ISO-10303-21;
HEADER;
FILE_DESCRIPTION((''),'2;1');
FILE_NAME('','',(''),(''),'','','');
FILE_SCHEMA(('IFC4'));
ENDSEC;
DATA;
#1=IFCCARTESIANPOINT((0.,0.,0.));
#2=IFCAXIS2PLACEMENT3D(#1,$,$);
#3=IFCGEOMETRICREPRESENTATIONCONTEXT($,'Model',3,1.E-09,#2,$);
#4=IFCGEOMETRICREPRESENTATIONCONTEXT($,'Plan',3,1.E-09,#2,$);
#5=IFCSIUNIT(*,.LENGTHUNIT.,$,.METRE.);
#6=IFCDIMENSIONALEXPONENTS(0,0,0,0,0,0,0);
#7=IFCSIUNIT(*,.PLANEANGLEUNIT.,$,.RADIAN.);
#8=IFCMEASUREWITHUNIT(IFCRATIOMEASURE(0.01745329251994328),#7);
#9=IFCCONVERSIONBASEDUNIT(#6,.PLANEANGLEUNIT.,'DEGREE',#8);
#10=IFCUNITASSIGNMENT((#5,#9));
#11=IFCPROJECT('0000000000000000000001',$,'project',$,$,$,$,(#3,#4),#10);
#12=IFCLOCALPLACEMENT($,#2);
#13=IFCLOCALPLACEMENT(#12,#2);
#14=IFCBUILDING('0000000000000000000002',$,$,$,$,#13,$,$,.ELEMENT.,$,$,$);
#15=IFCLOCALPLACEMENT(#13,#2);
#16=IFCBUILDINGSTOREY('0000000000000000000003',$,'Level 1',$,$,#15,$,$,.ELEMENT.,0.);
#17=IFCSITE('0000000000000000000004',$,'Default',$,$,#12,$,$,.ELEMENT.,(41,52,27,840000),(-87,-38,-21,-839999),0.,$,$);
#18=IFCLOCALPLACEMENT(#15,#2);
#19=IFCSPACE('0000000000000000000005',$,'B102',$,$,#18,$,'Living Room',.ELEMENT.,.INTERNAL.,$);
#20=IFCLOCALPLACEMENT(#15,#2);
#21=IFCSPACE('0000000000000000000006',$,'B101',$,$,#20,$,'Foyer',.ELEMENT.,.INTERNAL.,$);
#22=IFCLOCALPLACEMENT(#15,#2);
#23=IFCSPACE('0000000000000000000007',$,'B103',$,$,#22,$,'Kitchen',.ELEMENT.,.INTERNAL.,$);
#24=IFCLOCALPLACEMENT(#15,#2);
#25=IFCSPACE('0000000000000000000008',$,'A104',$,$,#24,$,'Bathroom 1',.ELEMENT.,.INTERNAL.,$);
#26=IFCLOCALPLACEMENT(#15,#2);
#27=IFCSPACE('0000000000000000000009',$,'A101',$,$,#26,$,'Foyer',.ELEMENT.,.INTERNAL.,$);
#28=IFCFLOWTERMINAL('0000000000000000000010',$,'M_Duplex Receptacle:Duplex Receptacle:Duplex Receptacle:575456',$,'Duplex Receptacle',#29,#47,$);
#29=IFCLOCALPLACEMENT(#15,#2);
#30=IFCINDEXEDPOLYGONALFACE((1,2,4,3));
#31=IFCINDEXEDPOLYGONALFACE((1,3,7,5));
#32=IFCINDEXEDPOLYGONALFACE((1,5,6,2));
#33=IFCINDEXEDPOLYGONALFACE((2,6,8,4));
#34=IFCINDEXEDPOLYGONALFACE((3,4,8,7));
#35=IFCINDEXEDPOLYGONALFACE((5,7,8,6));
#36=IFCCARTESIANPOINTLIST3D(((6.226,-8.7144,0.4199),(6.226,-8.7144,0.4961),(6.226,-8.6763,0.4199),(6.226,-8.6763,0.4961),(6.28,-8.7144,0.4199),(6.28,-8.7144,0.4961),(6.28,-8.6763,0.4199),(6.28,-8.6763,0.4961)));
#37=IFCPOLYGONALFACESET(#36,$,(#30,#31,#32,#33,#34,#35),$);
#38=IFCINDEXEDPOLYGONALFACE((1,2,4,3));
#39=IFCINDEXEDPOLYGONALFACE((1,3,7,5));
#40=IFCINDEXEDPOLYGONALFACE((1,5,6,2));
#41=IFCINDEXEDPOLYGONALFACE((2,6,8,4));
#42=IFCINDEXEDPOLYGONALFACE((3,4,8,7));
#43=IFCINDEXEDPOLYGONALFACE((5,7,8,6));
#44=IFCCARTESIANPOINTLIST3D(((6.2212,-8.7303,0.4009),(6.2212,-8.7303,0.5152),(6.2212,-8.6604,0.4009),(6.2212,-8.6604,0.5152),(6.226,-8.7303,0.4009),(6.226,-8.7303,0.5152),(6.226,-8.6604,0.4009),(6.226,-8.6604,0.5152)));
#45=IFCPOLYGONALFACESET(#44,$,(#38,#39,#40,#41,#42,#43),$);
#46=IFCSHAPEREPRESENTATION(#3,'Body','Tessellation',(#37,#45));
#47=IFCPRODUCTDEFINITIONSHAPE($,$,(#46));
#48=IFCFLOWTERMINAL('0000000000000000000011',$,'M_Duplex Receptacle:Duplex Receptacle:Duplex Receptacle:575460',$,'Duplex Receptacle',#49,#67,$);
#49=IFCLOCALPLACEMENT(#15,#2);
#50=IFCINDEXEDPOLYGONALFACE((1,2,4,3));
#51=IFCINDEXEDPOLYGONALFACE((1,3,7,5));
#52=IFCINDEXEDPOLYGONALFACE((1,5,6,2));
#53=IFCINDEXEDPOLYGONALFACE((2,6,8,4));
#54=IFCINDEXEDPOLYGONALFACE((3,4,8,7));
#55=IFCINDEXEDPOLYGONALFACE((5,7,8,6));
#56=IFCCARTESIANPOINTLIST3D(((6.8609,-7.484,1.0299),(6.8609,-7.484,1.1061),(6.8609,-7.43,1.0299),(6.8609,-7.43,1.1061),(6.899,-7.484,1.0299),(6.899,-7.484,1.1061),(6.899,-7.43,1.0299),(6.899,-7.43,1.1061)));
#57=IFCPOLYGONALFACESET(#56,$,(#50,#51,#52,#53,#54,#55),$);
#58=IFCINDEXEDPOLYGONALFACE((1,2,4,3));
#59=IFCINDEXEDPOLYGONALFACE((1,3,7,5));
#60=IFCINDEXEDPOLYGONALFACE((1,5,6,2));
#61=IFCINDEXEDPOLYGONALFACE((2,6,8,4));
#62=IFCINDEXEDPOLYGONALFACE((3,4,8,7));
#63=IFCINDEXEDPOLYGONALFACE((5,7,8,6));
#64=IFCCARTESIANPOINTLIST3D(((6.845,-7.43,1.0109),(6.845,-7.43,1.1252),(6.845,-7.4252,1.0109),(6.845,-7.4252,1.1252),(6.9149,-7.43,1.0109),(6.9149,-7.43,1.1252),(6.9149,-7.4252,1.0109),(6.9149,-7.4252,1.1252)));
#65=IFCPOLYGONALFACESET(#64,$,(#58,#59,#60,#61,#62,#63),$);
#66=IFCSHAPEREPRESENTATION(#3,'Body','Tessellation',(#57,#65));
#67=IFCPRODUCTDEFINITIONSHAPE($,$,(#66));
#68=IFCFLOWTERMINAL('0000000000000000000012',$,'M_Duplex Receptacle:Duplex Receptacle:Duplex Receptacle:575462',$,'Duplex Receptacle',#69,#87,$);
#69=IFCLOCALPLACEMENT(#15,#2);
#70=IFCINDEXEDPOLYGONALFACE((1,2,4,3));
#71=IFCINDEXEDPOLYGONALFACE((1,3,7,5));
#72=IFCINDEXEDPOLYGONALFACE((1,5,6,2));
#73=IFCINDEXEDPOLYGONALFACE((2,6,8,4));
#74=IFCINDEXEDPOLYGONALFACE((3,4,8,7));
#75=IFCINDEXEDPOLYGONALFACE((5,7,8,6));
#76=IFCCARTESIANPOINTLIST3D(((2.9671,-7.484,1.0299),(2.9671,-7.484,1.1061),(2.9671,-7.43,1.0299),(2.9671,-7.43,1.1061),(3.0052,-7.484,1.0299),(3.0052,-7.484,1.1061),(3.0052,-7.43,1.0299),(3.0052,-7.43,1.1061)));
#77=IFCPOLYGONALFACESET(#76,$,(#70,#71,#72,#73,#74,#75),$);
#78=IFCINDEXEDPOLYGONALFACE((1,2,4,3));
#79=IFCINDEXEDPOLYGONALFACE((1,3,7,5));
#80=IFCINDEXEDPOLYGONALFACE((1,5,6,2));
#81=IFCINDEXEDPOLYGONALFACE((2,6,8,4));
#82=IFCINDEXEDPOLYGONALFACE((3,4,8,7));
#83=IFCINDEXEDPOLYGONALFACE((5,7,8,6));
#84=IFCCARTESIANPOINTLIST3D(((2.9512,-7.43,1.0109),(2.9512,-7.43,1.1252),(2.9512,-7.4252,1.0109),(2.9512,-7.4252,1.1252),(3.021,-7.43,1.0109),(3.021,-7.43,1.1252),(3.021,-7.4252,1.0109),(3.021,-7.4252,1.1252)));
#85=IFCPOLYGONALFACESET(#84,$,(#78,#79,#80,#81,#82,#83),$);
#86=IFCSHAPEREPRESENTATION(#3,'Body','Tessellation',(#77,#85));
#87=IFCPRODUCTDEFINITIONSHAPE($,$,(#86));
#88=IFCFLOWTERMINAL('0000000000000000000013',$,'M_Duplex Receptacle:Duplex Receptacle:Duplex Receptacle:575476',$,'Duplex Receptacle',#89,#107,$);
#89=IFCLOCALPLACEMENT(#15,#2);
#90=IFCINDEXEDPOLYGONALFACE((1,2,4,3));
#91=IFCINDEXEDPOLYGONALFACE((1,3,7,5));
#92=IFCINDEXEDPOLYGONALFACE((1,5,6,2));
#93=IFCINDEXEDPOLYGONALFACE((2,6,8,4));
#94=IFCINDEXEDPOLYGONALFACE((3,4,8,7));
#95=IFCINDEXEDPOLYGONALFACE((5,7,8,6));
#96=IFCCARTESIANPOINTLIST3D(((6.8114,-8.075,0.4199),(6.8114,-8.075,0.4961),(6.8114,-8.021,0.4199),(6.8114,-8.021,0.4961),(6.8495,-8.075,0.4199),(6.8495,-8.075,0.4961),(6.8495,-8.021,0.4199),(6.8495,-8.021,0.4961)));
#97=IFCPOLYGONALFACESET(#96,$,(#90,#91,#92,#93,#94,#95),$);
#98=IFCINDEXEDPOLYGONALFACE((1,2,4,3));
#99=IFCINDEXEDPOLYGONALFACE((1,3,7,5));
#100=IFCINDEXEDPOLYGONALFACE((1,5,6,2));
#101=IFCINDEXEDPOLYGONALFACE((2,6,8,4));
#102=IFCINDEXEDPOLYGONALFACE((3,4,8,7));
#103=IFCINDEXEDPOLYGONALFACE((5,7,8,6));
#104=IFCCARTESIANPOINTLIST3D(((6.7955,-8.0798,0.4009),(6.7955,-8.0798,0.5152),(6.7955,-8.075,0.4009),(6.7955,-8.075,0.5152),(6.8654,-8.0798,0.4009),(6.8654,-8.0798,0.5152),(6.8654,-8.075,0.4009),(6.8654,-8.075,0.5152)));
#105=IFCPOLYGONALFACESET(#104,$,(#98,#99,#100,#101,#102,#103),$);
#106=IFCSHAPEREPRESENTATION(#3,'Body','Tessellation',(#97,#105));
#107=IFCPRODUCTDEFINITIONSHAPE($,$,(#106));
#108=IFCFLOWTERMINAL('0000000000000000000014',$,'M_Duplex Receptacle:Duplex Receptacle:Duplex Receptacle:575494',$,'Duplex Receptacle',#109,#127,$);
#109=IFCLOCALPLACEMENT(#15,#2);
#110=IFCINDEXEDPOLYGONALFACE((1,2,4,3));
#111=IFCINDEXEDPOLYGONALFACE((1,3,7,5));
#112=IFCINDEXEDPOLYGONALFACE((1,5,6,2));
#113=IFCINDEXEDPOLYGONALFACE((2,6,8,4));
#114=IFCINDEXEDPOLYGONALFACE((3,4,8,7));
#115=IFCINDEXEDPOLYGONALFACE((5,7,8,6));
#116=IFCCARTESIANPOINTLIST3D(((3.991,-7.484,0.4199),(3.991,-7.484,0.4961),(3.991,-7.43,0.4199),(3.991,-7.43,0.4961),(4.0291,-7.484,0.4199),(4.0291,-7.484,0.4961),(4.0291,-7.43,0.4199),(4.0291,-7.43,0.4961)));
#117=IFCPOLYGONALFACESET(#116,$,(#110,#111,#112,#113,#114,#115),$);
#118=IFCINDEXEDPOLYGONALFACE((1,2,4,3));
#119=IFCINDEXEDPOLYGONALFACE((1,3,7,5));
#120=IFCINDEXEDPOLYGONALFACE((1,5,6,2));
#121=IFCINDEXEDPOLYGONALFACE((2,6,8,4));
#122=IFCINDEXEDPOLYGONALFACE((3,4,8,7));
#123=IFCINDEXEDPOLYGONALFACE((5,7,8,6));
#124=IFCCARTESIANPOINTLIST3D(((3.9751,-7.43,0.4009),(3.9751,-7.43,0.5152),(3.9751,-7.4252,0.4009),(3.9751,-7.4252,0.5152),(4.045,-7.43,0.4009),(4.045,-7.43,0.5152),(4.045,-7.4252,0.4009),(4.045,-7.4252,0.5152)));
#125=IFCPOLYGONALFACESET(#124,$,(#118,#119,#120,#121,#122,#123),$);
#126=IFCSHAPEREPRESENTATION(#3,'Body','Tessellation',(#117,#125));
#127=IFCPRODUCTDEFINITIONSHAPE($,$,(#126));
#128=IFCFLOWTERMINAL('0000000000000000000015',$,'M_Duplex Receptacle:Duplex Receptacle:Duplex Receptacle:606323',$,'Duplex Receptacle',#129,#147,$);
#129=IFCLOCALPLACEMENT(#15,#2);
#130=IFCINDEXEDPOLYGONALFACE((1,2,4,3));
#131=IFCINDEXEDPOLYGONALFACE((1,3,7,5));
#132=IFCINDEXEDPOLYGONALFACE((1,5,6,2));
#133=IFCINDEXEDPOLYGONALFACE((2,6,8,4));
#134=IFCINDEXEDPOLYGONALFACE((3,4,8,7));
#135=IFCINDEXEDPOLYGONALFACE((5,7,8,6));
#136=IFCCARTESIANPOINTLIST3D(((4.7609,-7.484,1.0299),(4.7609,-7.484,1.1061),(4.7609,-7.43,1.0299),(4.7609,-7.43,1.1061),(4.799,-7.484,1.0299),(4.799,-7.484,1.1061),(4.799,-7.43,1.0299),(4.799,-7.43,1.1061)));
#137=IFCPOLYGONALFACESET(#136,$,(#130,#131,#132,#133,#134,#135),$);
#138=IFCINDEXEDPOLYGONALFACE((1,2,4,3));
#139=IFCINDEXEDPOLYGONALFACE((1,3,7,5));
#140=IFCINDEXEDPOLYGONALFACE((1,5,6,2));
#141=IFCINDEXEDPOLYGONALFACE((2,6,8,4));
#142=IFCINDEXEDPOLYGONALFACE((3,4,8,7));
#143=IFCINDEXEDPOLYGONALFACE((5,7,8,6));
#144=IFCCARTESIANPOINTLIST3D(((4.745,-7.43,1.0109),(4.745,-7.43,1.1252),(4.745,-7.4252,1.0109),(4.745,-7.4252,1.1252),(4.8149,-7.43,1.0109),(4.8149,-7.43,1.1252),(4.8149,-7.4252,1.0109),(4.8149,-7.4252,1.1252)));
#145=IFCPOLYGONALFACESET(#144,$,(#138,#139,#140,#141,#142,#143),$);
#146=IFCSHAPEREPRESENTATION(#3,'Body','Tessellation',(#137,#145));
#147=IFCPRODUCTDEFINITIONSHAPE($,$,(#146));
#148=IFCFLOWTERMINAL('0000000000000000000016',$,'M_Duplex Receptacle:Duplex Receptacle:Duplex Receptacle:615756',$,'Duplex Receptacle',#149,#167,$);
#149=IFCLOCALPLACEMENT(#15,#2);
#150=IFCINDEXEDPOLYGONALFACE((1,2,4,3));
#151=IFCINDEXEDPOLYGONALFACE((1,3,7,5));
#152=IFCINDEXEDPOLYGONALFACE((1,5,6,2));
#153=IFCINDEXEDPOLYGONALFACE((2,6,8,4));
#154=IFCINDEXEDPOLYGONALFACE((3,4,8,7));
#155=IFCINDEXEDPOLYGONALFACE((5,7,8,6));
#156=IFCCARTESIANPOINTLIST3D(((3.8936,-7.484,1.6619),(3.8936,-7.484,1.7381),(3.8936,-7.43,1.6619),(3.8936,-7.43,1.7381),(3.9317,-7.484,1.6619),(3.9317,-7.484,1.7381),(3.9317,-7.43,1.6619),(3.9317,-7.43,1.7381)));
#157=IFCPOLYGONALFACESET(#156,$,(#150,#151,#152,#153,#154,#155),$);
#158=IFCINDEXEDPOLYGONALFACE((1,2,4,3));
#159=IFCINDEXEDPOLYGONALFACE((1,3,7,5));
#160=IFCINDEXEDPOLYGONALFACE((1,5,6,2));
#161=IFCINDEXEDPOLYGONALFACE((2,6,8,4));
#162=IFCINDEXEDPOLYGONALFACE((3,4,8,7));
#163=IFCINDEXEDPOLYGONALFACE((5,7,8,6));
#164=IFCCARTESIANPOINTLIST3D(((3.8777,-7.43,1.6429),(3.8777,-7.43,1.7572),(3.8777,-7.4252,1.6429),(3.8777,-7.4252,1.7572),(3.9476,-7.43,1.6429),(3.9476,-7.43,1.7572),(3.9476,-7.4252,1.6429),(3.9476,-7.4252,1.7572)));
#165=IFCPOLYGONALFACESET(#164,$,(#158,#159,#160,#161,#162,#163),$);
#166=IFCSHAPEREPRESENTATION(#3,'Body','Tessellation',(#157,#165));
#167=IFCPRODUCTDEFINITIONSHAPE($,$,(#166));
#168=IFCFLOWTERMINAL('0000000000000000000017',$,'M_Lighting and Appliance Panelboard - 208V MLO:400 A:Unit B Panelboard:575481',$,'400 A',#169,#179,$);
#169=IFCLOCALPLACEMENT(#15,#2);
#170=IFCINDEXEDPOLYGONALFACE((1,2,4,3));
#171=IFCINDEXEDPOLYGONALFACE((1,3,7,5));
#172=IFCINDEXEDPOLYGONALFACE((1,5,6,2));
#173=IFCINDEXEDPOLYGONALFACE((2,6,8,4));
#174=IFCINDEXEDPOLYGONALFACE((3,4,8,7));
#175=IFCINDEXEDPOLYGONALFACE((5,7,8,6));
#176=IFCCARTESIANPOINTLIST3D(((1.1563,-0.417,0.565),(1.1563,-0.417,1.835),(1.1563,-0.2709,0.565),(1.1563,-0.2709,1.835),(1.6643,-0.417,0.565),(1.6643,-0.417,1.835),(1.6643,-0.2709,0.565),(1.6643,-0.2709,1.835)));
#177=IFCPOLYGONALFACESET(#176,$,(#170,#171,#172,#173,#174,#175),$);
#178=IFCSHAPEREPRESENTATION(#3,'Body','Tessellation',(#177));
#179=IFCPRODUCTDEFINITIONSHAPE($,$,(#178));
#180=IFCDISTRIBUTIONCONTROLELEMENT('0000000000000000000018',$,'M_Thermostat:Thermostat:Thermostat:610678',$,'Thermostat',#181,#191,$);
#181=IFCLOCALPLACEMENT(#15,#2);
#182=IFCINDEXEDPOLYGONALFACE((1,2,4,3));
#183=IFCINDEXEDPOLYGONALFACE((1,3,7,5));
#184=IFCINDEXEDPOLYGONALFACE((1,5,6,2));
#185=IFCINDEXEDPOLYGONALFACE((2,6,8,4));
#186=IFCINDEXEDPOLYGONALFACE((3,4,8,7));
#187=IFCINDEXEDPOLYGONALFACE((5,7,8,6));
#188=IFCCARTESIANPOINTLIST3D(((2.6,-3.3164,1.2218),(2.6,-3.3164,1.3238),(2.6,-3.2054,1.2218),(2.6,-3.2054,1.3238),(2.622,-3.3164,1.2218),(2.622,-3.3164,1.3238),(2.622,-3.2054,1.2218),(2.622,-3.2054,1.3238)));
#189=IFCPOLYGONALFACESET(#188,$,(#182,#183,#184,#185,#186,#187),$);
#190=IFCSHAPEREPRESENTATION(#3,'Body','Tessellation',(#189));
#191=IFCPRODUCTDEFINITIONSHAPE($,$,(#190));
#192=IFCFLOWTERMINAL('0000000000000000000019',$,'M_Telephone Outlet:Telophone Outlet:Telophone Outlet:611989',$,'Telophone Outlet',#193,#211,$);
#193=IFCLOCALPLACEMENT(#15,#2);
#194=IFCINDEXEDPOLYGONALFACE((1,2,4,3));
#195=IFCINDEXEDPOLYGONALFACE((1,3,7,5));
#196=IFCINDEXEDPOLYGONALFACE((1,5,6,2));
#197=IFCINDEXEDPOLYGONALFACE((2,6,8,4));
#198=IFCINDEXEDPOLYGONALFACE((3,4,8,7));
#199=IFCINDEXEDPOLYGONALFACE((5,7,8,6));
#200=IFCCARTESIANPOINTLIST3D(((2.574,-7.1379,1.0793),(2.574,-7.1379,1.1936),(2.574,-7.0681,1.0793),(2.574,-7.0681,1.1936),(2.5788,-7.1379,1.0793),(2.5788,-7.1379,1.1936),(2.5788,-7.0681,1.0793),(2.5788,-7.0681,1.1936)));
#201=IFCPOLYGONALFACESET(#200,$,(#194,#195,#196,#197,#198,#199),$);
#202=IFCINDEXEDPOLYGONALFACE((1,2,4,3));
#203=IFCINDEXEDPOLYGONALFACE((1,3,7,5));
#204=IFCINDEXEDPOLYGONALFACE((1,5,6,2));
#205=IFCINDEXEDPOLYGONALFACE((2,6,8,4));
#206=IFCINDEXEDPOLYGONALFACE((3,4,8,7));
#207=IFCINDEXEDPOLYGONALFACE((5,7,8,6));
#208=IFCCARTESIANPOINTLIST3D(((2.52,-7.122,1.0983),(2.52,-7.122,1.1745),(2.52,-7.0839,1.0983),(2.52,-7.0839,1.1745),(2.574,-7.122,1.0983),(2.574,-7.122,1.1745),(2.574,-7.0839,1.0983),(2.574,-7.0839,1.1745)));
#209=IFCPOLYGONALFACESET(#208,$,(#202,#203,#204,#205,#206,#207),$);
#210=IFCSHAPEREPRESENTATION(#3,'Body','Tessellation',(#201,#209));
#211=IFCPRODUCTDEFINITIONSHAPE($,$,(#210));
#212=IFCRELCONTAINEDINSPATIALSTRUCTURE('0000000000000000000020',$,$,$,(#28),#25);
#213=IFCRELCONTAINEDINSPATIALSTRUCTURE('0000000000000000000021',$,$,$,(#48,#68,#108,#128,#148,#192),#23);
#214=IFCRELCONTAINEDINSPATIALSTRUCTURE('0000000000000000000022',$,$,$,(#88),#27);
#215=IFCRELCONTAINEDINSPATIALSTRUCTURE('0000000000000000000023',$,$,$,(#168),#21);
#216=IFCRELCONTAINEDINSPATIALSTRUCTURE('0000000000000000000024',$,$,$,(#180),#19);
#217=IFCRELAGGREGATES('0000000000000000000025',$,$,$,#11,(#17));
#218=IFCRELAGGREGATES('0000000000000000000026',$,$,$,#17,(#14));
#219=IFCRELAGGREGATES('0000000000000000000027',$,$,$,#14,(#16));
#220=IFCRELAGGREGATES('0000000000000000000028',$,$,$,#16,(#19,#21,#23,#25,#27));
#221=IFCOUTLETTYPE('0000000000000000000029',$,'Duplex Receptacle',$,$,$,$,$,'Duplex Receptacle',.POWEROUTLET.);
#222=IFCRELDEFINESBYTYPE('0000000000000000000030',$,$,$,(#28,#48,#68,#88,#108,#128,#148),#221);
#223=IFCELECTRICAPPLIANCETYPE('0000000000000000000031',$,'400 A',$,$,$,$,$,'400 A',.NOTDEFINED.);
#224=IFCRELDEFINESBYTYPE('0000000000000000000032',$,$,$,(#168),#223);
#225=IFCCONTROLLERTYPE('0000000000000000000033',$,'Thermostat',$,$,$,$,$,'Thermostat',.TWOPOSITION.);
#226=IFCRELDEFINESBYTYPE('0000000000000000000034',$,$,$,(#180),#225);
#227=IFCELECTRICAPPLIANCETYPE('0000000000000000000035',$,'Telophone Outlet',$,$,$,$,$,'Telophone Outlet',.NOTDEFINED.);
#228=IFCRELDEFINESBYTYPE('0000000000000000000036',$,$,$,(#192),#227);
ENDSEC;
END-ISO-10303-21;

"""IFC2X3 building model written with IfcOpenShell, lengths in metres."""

from ifc_helpers import new_model, entity, si_unit, converted_unit, frame, origin, origin_2d_with_axis, place, context, project, spatial, rectangle, extrude, source, transform, mapped, type_object, type_shapes, element, save


model = new_model("IFC2X3")

# Units and contexts
model_context = context("Model", 3, precision=1e-09, world=origin())
plan_context = context("Plan", 3, precision=1e-09, world=origin())
ifc_project = project(units=[si_unit("LENGTHUNIT", "METRE"), converted_unit("PLANEANGLEUNIT", "DEGREE", entity("IfcRatioMeasure", 0.01745329251994328), si_unit("PLANEANGLEUNIT", "RADIAN"), dimensions=[0, 0, 0, 0, 0, 0, 0])], contexts=[model_context, plan_context])

# Site, building, storey
site_placement = place(None, origin())
site = spatial("IfcSite", under=ifc_project, at=site_placement, Name="Default", CompositionType="ELEMENT", RefLatitude=(41, 52, 27, 840000), RefLongitude=(-87, -38, -21, -839999), RefElevation=0.0)
building_placement = place(site_placement, origin())
building = spatial("IfcBuilding", under=site, at=building_placement, CompositionType="ELEMENT")
storey_placement = place(building_placement, origin())
storey = spatial("IfcBuildingStorey", under=building, at=storey_placement, Name="Level 1", CompositionType="ELEMENT", Elevation=0.0)

# Shared definitions
space_1_placement = place(storey_placement, origin())
space_1 = spatial("IfcSpace", under=storey, at=space_1_placement, Name="B102", LongName="Living Room", CompositionType="ELEMENT", InteriorOrExteriorSpace="INTERNAL")

# Shared definitions
space_2_placement = place(storey_placement, origin())
space_2 = spatial("IfcSpace", under=storey, at=space_2_placement, Name="B101", LongName="Foyer", CompositionType="ELEMENT", InteriorOrExteriorSpace="INTERNAL")

# Shared definitions
space_3_placement = place(storey_placement, origin())
space_3 = spatial("IfcSpace", under=storey, at=space_3_placement, Name="B103", LongName="Kitchen", CompositionType="ELEMENT", InteriorOrExteriorSpace="INTERNAL")

# Shared definitions
outlet_type = type_object("IfcOutletType", Name="Duplex Receptacle", ElementType="Duplex Receptacle", PredefinedType="POWEROUTLET")
shared_shape_1 = source(origin(), model_context, "Body", "SweptSolid", [
    extrude(rectangle(XDim=0.0381, YDim=0.0762, at=origin_2d_with_axis()), frame((0.0, 0.0, -0.054), z_axis=(0.0, 0.0, 1.0), x_axis=(-1.0, 0.0, 0.0)), (0.0, 0.0, 1.0), 0.054),
    extrude(rectangle(XDim=0.0698, YDim=0.1143, at=origin_2d_with_axis()), frame((0.0, 0.0, 0.0), z_axis=(0.0, 0.0, 1.0), x_axis=(-1.0, 0.0, 0.0)), (0.0, 0.0, 1.0), 0.0048),
])
type_shapes(outlet_type, [shared_shape_1])

# Shared definitions
space_4_placement = place(storey_placement, origin())
space_4 = spatial("IfcSpace", under=storey, at=space_4_placement, Name="A104", LongName="Bathroom 1", CompositionType="ELEMENT", InteriorOrExteriorSpace="INTERNAL")

# Flow terminals
flow_terminal_1_placement = place(space_4_placement, frame((6.226, -8.6953, 0.458), z_axis=(-1.0, 0.0, 0.0), x_axis=(0.0, -1.0, 0.0)))
element("IfcFlowTerminal", 1, at=flow_terminal_1_placement, inside=space_4, type_object=outlet_type, Name="M_Duplex Receptacle:Duplex Receptacle:Duplex Receptacle:575456", ObjectType="Duplex Receptacle", context=model_context, shape_type="MappedRepresentation", body=[
    mapped(shared_shape_1, transform((0.0, 0.0, 0.0), scale=1.0)),
])
for number, where, z_axis, x_axis, name in (
    (2, (6.88, -7.43, 1.068), (0.0, 1.0, 0.0), (-1.0, 0.0, 0.0), "M_Duplex Receptacle:Duplex Receptacle:Duplex Receptacle:575460"),
    (3, (2.9861, -7.43, 1.068), (0.0, 1.0, 0.0), (-1.0, 0.0, 0.0), "M_Duplex Receptacle:Duplex Receptacle:Duplex Receptacle:575462"),
):
    element("IfcFlowTerminal", number, at=place(space_3_placement, frame(where, z_axis=z_axis, x_axis=x_axis)), inside=space_3, type_object=outlet_type, Name=name, ObjectType="Duplex Receptacle", context=model_context, shape_type="MappedRepresentation", body=[
        mapped(shared_shape_1, transform((0.0, 0.0, 0.0), scale=1.0)),
    ])

# Shared definitions
space_5_placement = place(storey_placement, origin())
space_5 = spatial("IfcSpace", under=storey, at=space_5_placement, Name="A101", LongName="Foyer", CompositionType="ELEMENT", InteriorOrExteriorSpace="INTERNAL")

# Flow terminals
flow_terminal_2_placement = place(space_5_placement, frame((6.8305, -8.075, 0.458), z_axis=(0.0, -1.0, 0.0), x_axis=(1.0, 0.0, 0.0)))
element("IfcFlowTerminal", 4, at=flow_terminal_2_placement, inside=space_5, type_object=outlet_type, Name="M_Duplex Receptacle:Duplex Receptacle:Duplex Receptacle:575476", ObjectType="Duplex Receptacle", context=model_context, shape_type="MappedRepresentation", body=[
    mapped(shared_shape_1, transform((0.0, 0.0, 0.0), scale=1.0)),
])
for number, where, z_axis, x_axis, name in (
    (5, (4.0101, -7.43, 0.458), (0.0, 1.0, 0.0), (-1.0, 0.0, 0.0), "M_Duplex Receptacle:Duplex Receptacle:Duplex Receptacle:575494"),
    (6, (4.78, -7.43, 1.068), (0.0, 1.0, 0.0), (-1.0, 0.0, 0.0), "M_Duplex Receptacle:Duplex Receptacle:Duplex Receptacle:606323"),
    (7, (3.9127, -7.43, 1.7), (0.0, 1.0, 0.0), (-1.0, 0.0, 0.0), "M_Duplex Receptacle:Duplex Receptacle:Duplex Receptacle:615756"),
):
    element("IfcFlowTerminal", number, at=place(space_3_placement, frame(where, z_axis=z_axis, x_axis=x_axis)), inside=space_3, type_object=outlet_type, Name=name, ObjectType="Duplex Receptacle", context=model_context, shape_type="MappedRepresentation", body=[
        mapped(shared_shape_1, transform((0.0, 0.0, 0.0), scale=1.0)),
    ])
electric_appliance_type_1 = type_object("IfcElectricApplianceType", Name="400 A", ElementType="400 A", PredefinedType="NOTDEFINED")
shared_shape_2 = source(origin(), model_context, "Body", "SweptSolid", [
    extrude(rectangle(XDim=0.508, YDim=1.27, at=origin_2d_with_axis()), frame((0.0, -0.4191, -0.1461), z_axis=(0.0, 0.0, 1.0), x_axis=(-1.0, 0.0, 0.0)), (0.0, 0.0, 1.0), 0.1461),
])
type_shapes(electric_appliance_type_1, [shared_shape_2])
flow_terminal_3_placement = place(space_2_placement, frame((1.4103, -0.417, 1.6191), z_axis=(0.0, -1.0, 0.0), x_axis=(1.0, 0.0, 0.0)))
element("IfcFlowTerminal", 8, at=flow_terminal_3_placement, inside=space_2, type_object=electric_appliance_type_1, Name="M_Lighting and Appliance Panelboard - 208V MLO:400 A:Unit B Panelboard:575481", ObjectType="400 A", context=model_context, shape_type="MappedRepresentation", body=[
    mapped(shared_shape_2, transform((0.0, 0.0, 0.0), scale=1.0)),
])

# Distribution control element
controller_type = type_object("IfcControllerType", Name="Thermostat", ElementType="Thermostat", PredefinedType="TWOPOSITION")
shared_shape_3 = source(origin(), model_context, "Body", "SweptSolid", [
    extrude(rectangle(XDim=0.102, YDim=0.111, at=origin_2d_with_axis()), frame((0.0, -0.051, 0.0), z_axis=(0.0, 0.0, 1.0), x_axis=(0.0, 1.0, 0.0)), (0.0, 0.0, 1.0), 0.022),
])
type_shapes(controller_type, [shared_shape_3])
distribution_control_element_placement = place(space_1_placement, frame((2.6, -3.2609, 1.3238), z_axis=(1.0, 0.0, 0.0), x_axis=(0.0, 1.0, 0.0)))
element("IfcDistributionControlElement", 9, at=distribution_control_element_placement, inside=space_1, type_object=controller_type, Name="M_Thermostat:Thermostat:Thermostat:610678", ObjectType="Thermostat", context=model_context, shape_type="MappedRepresentation", body=[
    mapped(shared_shape_3, transform((0.0, 0.0, 0.0), scale=1.0)),
])

# Flow terminal
electric_appliance_type_2 = type_object("IfcElectricApplianceType", Name="Telophone Outlet", ElementType="Telophone Outlet", PredefinedType="NOTDEFINED")
shared_shape_4 = source(origin(), model_context, "Body", "SweptSolid", [
    extrude(rectangle(XDim=0.0699, YDim=0.1143, at=origin_2d_with_axis()), frame((0.0, 0.0, 0.0), z_axis=(0.0, 0.0, 1.0), x_axis=(-1.0, 0.0, 0.0)), (0.0, 0.0, 1.0), 0.0048),
    extrude(rectangle(XDim=0.0381, YDim=0.0762, at=origin_2d_with_axis()), frame((0.0, 0.0, -0.054), z_axis=(0.0, 0.0, 1.0), x_axis=(-1.0, 0.0, 0.0)), (0.0, 0.0, 1.0), 0.054),
])
type_shapes(electric_appliance_type_2, [shared_shape_4])
flow_terminal_4_placement = place(space_3_placement, frame((2.574, -7.103, 1.1364), z_axis=(1.0, 0.0, 0.0), x_axis=(0.0, 1.0, 0.0)))
element("IfcFlowTerminal", 10, at=flow_terminal_4_placement, inside=space_3, type_object=electric_appliance_type_2, Name="M_Telephone Outlet:Telophone Outlet:Telophone Outlet:611989", ObjectType="Telophone Outlet", context=model_context, shape_type="MappedRepresentation", body=[
    mapped(shared_shape_4, transform((0.0, 0.0, 0.0), scale=1.0)),
])

save(model, "model.ifc")
